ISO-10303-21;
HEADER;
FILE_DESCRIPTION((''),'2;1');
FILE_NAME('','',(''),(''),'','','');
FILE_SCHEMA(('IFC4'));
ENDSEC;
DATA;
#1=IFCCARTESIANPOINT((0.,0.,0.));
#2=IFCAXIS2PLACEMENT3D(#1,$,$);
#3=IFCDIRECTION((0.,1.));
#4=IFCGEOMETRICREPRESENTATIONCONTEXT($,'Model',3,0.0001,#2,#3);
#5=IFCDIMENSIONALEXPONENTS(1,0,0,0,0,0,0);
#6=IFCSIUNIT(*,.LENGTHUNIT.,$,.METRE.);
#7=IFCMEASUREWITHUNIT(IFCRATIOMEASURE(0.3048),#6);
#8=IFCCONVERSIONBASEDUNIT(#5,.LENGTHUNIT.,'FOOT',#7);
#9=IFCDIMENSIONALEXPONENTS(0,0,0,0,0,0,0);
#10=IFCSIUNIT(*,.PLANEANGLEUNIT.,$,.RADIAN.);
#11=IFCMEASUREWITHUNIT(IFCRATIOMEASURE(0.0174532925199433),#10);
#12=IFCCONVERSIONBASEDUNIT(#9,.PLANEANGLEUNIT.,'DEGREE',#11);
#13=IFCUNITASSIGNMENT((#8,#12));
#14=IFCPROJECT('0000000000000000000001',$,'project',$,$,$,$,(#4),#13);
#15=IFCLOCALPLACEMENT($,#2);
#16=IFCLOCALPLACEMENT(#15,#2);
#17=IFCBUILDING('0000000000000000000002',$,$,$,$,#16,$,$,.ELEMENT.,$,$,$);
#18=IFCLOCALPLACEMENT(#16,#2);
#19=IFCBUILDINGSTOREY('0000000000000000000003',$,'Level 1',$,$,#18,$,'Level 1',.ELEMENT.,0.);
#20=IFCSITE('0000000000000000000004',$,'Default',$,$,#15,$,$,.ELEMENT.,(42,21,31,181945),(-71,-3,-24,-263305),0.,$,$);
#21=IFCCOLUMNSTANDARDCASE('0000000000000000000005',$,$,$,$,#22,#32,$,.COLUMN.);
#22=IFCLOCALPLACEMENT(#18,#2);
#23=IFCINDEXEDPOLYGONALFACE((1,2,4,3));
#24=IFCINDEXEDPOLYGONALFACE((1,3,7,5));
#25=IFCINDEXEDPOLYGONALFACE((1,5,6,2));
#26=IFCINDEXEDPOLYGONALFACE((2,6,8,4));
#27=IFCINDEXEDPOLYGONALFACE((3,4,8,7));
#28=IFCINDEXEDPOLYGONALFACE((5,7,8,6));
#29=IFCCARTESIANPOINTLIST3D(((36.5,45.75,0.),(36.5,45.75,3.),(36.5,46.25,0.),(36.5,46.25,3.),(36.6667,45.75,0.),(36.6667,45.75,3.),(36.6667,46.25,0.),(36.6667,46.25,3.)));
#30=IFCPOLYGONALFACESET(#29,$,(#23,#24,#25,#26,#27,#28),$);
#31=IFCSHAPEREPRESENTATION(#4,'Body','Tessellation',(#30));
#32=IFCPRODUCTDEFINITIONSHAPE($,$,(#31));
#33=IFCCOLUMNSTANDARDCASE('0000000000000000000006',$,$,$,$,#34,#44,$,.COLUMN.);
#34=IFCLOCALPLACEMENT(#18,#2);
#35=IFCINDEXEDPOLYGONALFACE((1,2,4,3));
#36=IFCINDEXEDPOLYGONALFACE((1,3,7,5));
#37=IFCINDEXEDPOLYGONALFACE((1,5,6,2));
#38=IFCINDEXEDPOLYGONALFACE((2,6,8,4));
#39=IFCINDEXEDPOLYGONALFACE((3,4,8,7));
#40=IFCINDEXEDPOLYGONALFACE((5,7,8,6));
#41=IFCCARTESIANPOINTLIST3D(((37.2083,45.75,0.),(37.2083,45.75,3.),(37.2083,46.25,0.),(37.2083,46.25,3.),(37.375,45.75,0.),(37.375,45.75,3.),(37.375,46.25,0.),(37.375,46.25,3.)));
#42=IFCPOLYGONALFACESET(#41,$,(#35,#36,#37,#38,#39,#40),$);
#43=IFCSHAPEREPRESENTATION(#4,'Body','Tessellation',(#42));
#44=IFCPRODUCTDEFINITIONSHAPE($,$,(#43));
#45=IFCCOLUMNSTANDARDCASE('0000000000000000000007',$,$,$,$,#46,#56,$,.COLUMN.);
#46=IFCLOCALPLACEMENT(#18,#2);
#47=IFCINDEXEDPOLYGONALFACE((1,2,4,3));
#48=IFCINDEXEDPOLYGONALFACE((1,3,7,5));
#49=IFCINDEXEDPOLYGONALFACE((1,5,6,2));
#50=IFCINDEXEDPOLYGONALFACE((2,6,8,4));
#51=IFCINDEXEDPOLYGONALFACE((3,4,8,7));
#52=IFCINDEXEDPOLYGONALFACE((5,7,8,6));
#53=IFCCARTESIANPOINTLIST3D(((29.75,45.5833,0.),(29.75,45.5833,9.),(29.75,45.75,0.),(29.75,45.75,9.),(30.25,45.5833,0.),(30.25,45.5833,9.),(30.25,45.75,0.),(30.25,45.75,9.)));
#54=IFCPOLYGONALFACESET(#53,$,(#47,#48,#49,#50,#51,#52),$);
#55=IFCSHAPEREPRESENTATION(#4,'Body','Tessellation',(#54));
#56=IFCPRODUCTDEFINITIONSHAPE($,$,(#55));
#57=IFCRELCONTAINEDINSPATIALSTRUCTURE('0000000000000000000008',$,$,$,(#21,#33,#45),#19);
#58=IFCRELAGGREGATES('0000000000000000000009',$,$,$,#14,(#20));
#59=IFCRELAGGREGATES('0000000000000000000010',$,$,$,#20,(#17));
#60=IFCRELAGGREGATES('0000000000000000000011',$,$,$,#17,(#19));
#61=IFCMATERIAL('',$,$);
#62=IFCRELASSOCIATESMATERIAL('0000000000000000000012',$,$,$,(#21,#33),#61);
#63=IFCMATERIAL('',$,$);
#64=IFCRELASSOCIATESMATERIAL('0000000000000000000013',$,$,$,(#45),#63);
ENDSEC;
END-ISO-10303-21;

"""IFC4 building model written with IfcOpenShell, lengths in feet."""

from ifc_helpers import new_model, entity, si_unit, converted_unit, direction, frame, origin, place, context, project, spatial, rectangle, extrude, material, element, save


model = new_model("IFC4")

# Units and contexts
model_context = context("Model", 3, precision=0.0001, world=origin(), true_north=direction((0.0, 1.0)))
ifc_project = project(units=[converted_unit("LENGTHUNIT", "FOOT", entity("IfcRatioMeasure", 0.3048), si_unit("LENGTHUNIT", "METRE"), dimensions=[1, 0, 0, 0, 0, 0, 0]), converted_unit("PLANEANGLEUNIT", "DEGREE", entity("IfcRatioMeasure", 0.0174532925199433), si_unit("PLANEANGLEUNIT", "RADIAN"), dimensions=[0, 0, 0, 0, 0, 0, 0])], contexts=[model_context])

# Site, building, storey
site_placement = place(None, origin())
site = spatial("IfcSite", under=ifc_project, at=site_placement, Name="Default", CompositionType="ELEMENT", RefLatitude=(42, 21, 31, 181945), RefLongitude=(-71, -3, -24, -263305), RefElevation=0.0)
building_placement = place(site_placement, origin())
building = spatial("IfcBuilding", under=site, at=building_placement, CompositionType="ELEMENT")
storey_placement = place(building_placement, origin())
storey = spatial("IfcBuildingStorey", under=building, at=storey_placement, Name="Level 1", LongName="Level 1", CompositionType="ELEMENT", Elevation=0.0)

# Columns
placement = place(storey_placement, frame((-0.25, 46.0, 0.0)))
ifc_material_1 = material(Name="")
for number, where, z_axis, x_axis in (
    (1, (36.8334, 0.0, 0.0), (0.0, 0.0, 1.0), (1.0, 0.0, 0.0)),
    (2, (37.5417, 0.0, 0.0), (0.0, 0.0, 1.0), (1.0, 0.0, 0.0)),
):
    element("IfcColumnStandardCase", number, at=place(placement, frame(where, z_axis=z_axis, x_axis=x_axis)), inside=storey, material=ifc_material_1, PredefinedType="COLUMN", context=model_context, shape_type="SweptSolid", body=[
        extrude(rectangle(XDim=0.1667, YDim=0.5), origin(), (0.0, 0.0, 1.0), 3.0),
    ])
ifc_material_2 = material(Name="")
wall_placement = place(storey_placement, frame((30.0, 45.75, 0.0), z_axis=(0.0, 0.0, 1.0), x_axis=(0.0, -1.0, 0.0)))
for number, where, z_axis, x_axis in (
    (3, (0.0833, 0.0, 0.0), (0.0, 0.0, 1.0), (1.0, 0.0, 0.0)),
):
    element("IfcColumnStandardCase", number, at=place(wall_placement, frame(where, z_axis=z_axis, x_axis=x_axis)), inside=storey, material=ifc_material_2, PredefinedType="COLUMN", context=model_context, shape_type="SweptSolid", body=[
        extrude(rectangle(XDim=0.1667, YDim=0.5), origin(), (0.0, 0.0, 1.0), 9.0),
    ])

save(model, "model.ifc")
